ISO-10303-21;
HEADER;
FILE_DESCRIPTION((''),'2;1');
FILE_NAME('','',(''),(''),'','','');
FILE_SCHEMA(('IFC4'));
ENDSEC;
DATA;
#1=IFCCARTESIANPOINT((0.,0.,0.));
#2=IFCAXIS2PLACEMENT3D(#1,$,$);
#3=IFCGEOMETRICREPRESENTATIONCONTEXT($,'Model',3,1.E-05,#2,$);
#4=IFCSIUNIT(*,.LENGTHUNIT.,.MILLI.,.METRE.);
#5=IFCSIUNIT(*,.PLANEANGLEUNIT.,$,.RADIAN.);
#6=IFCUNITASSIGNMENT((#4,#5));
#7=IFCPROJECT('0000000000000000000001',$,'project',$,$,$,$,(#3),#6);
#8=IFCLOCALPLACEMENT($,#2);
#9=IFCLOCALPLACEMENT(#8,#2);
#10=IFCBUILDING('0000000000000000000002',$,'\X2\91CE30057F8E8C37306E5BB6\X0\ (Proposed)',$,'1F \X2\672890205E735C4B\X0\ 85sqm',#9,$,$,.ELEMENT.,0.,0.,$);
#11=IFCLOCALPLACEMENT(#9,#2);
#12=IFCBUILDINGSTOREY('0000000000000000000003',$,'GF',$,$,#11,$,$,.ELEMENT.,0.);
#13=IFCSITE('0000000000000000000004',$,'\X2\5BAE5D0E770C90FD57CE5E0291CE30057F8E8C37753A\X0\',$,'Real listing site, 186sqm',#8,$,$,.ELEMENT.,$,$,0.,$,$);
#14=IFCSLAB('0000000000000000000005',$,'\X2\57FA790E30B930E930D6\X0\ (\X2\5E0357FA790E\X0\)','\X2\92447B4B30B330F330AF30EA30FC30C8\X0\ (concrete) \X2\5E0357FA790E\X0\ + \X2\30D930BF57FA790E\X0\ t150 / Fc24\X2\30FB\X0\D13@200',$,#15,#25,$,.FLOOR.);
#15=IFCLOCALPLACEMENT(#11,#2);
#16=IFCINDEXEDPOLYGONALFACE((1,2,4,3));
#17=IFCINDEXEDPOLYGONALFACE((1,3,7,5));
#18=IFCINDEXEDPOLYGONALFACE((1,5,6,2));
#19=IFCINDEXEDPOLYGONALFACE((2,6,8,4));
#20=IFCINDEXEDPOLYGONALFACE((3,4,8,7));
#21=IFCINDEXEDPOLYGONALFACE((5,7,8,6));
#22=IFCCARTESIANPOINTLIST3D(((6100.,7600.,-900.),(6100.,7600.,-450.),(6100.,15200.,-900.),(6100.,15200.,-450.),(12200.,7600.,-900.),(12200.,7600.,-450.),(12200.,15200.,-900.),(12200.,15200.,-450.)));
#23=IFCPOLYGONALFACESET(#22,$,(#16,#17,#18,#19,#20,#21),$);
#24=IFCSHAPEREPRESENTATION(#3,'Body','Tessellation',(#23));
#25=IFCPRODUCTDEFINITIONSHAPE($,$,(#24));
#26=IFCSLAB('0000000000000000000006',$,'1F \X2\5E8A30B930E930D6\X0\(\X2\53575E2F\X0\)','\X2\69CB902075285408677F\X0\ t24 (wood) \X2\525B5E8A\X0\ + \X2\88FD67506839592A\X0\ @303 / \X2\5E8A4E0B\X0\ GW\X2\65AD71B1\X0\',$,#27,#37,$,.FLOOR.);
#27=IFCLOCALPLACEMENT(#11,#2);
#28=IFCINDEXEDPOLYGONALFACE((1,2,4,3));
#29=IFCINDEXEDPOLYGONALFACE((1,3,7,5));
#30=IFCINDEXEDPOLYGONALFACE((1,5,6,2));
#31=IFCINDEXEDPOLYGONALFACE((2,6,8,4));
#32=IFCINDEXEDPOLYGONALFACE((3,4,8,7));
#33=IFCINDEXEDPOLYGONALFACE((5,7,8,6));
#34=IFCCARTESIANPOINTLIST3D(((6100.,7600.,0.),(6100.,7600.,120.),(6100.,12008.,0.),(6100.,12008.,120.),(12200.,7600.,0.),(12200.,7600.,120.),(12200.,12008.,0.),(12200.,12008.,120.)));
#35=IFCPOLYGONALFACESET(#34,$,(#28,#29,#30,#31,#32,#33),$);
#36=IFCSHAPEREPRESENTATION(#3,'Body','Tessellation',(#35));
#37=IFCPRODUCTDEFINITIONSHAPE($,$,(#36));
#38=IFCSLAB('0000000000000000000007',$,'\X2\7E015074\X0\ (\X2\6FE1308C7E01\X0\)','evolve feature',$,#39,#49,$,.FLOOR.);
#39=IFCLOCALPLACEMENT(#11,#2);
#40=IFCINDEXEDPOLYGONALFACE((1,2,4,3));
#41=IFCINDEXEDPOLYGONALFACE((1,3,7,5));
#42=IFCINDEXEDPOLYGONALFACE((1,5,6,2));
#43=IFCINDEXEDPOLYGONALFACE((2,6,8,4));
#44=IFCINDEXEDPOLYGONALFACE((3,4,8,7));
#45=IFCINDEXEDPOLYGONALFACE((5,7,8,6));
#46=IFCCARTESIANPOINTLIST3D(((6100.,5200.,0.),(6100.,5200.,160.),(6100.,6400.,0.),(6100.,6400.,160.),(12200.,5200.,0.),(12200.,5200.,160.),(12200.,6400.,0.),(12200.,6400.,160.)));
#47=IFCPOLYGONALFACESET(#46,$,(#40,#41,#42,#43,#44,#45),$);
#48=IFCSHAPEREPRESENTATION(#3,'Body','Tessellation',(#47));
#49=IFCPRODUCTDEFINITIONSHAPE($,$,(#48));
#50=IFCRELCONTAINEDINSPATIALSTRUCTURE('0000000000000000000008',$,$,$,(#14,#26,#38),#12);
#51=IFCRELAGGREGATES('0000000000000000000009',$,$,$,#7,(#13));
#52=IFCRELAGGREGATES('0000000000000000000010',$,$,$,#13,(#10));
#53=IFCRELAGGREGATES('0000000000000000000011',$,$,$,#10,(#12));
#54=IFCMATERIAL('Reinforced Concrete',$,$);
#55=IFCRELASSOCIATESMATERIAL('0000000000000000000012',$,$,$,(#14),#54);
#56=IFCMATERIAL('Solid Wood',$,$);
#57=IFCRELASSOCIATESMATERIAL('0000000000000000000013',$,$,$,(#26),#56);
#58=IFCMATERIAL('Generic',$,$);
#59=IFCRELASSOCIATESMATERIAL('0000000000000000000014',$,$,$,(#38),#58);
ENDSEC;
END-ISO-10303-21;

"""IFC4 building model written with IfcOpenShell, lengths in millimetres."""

from ifc_helpers import new_model, si_unit, frame, frame_2d, origin, place, context, project, spatial, rectangle, extrude, material, element, save


model = new_model("IFC4")

# Units and contexts
model_context = context("Model", 3, precision=1e-05, world=origin())
ifc_project = project(units=[si_unit("LENGTHUNIT", "METRE", prefix="MILLI"), si_unit("PLANEANGLEUNIT", "RADIAN")], contexts=[model_context])

# Site, building, storey
site_placement = place(None, origin())
site = spatial("IfcSite", under=ifc_project, at=site_placement, Name="宮崎県都城市野々美谷町", ObjectType="Real listing site, 186sqm", CompositionType="ELEMENT", RefElevation=0.0)
building_placement = place(site_placement, origin())
building = spatial("IfcBuilding", under=site, at=building_placement, Name="野々美谷の家 (Proposed)", ObjectType="1F 木造平屋 85sqm", CompositionType="ELEMENT", ElevationOfRefHeight=0.0, ElevationOfTerrain=0.0)
storey_placement = place(building_placement, origin())
storey = spatial("IfcBuildingStorey", under=building, at=storey_placement, Name="GF", CompositionType="ELEMENT", Elevation=0.0)

# Slabs
ifc_material_1 = material(Name="Reinforced Concrete")
slab_1_placement = place(storey_placement, frame((3050.0, 3800.0, -450.0)))
element("IfcSlab", 1, at=slab_1_placement, inside=storey, material=ifc_material_1, Name="基礎スラブ (布基礎)", Description="鉄筋コンクリート (concrete) 布基礎 + ベタ基礎 t150 / Fc24・D13@200", PredefinedType="FLOOR", context=model_context, shape_type="SweptSolid", body=[
    extrude(rectangle(XDim=6100.0, YDim=7600.0, at=frame_2d((3050.0, 3800.0))), frame((3050.0, 3800.0, -450.0)), (0.0, 0.0, 1.0), 450.0),
])
ifc_material_2 = material(Name="Solid Wood")
slab_2_placement = place(storey_placement, frame((3050.0, 3800.0, 0.0)))
element("IfcSlab", 2, at=slab_2_placement, inside=storey, material=ifc_material_2, Name="1F 床スラブ(南帯)", Description="構造用合板 t24 (wood) 剛床 + 製材根太 @303 / 床下 GW断熱", PredefinedType="FLOOR", context=model_context, shape_type="SweptSolid", body=[
    extrude(rectangle(XDim=6100.0, YDim=4408.0, at=frame_2d((3050.0, 2204.0))), frame((3050.0, 3800.0, 0.0)), (0.0, 0.0, 1.0), 120.0),
])
ifc_material_3 = material(Name="Generic")
slab_3_placement = place(storey_placement, frame((3050.0, 2600.0, 0.0)))
element("IfcSlab", 3, at=slab_3_placement, inside=storey, material=ifc_material_3, Name="縁側 (濡れ縁)", Description="evolve feature", PredefinedType="FLOOR", context=model_context, shape_type="SweptSolid", body=[
    extrude(rectangle(XDim=6100.0, YDim=1200.0, at=frame_2d((3050.0, 600.0))), frame((3050.0, 2600.0, 0.0)), (0.0, 0.0, 1.0), 160.0),
])

save(model, "model.ifc")
